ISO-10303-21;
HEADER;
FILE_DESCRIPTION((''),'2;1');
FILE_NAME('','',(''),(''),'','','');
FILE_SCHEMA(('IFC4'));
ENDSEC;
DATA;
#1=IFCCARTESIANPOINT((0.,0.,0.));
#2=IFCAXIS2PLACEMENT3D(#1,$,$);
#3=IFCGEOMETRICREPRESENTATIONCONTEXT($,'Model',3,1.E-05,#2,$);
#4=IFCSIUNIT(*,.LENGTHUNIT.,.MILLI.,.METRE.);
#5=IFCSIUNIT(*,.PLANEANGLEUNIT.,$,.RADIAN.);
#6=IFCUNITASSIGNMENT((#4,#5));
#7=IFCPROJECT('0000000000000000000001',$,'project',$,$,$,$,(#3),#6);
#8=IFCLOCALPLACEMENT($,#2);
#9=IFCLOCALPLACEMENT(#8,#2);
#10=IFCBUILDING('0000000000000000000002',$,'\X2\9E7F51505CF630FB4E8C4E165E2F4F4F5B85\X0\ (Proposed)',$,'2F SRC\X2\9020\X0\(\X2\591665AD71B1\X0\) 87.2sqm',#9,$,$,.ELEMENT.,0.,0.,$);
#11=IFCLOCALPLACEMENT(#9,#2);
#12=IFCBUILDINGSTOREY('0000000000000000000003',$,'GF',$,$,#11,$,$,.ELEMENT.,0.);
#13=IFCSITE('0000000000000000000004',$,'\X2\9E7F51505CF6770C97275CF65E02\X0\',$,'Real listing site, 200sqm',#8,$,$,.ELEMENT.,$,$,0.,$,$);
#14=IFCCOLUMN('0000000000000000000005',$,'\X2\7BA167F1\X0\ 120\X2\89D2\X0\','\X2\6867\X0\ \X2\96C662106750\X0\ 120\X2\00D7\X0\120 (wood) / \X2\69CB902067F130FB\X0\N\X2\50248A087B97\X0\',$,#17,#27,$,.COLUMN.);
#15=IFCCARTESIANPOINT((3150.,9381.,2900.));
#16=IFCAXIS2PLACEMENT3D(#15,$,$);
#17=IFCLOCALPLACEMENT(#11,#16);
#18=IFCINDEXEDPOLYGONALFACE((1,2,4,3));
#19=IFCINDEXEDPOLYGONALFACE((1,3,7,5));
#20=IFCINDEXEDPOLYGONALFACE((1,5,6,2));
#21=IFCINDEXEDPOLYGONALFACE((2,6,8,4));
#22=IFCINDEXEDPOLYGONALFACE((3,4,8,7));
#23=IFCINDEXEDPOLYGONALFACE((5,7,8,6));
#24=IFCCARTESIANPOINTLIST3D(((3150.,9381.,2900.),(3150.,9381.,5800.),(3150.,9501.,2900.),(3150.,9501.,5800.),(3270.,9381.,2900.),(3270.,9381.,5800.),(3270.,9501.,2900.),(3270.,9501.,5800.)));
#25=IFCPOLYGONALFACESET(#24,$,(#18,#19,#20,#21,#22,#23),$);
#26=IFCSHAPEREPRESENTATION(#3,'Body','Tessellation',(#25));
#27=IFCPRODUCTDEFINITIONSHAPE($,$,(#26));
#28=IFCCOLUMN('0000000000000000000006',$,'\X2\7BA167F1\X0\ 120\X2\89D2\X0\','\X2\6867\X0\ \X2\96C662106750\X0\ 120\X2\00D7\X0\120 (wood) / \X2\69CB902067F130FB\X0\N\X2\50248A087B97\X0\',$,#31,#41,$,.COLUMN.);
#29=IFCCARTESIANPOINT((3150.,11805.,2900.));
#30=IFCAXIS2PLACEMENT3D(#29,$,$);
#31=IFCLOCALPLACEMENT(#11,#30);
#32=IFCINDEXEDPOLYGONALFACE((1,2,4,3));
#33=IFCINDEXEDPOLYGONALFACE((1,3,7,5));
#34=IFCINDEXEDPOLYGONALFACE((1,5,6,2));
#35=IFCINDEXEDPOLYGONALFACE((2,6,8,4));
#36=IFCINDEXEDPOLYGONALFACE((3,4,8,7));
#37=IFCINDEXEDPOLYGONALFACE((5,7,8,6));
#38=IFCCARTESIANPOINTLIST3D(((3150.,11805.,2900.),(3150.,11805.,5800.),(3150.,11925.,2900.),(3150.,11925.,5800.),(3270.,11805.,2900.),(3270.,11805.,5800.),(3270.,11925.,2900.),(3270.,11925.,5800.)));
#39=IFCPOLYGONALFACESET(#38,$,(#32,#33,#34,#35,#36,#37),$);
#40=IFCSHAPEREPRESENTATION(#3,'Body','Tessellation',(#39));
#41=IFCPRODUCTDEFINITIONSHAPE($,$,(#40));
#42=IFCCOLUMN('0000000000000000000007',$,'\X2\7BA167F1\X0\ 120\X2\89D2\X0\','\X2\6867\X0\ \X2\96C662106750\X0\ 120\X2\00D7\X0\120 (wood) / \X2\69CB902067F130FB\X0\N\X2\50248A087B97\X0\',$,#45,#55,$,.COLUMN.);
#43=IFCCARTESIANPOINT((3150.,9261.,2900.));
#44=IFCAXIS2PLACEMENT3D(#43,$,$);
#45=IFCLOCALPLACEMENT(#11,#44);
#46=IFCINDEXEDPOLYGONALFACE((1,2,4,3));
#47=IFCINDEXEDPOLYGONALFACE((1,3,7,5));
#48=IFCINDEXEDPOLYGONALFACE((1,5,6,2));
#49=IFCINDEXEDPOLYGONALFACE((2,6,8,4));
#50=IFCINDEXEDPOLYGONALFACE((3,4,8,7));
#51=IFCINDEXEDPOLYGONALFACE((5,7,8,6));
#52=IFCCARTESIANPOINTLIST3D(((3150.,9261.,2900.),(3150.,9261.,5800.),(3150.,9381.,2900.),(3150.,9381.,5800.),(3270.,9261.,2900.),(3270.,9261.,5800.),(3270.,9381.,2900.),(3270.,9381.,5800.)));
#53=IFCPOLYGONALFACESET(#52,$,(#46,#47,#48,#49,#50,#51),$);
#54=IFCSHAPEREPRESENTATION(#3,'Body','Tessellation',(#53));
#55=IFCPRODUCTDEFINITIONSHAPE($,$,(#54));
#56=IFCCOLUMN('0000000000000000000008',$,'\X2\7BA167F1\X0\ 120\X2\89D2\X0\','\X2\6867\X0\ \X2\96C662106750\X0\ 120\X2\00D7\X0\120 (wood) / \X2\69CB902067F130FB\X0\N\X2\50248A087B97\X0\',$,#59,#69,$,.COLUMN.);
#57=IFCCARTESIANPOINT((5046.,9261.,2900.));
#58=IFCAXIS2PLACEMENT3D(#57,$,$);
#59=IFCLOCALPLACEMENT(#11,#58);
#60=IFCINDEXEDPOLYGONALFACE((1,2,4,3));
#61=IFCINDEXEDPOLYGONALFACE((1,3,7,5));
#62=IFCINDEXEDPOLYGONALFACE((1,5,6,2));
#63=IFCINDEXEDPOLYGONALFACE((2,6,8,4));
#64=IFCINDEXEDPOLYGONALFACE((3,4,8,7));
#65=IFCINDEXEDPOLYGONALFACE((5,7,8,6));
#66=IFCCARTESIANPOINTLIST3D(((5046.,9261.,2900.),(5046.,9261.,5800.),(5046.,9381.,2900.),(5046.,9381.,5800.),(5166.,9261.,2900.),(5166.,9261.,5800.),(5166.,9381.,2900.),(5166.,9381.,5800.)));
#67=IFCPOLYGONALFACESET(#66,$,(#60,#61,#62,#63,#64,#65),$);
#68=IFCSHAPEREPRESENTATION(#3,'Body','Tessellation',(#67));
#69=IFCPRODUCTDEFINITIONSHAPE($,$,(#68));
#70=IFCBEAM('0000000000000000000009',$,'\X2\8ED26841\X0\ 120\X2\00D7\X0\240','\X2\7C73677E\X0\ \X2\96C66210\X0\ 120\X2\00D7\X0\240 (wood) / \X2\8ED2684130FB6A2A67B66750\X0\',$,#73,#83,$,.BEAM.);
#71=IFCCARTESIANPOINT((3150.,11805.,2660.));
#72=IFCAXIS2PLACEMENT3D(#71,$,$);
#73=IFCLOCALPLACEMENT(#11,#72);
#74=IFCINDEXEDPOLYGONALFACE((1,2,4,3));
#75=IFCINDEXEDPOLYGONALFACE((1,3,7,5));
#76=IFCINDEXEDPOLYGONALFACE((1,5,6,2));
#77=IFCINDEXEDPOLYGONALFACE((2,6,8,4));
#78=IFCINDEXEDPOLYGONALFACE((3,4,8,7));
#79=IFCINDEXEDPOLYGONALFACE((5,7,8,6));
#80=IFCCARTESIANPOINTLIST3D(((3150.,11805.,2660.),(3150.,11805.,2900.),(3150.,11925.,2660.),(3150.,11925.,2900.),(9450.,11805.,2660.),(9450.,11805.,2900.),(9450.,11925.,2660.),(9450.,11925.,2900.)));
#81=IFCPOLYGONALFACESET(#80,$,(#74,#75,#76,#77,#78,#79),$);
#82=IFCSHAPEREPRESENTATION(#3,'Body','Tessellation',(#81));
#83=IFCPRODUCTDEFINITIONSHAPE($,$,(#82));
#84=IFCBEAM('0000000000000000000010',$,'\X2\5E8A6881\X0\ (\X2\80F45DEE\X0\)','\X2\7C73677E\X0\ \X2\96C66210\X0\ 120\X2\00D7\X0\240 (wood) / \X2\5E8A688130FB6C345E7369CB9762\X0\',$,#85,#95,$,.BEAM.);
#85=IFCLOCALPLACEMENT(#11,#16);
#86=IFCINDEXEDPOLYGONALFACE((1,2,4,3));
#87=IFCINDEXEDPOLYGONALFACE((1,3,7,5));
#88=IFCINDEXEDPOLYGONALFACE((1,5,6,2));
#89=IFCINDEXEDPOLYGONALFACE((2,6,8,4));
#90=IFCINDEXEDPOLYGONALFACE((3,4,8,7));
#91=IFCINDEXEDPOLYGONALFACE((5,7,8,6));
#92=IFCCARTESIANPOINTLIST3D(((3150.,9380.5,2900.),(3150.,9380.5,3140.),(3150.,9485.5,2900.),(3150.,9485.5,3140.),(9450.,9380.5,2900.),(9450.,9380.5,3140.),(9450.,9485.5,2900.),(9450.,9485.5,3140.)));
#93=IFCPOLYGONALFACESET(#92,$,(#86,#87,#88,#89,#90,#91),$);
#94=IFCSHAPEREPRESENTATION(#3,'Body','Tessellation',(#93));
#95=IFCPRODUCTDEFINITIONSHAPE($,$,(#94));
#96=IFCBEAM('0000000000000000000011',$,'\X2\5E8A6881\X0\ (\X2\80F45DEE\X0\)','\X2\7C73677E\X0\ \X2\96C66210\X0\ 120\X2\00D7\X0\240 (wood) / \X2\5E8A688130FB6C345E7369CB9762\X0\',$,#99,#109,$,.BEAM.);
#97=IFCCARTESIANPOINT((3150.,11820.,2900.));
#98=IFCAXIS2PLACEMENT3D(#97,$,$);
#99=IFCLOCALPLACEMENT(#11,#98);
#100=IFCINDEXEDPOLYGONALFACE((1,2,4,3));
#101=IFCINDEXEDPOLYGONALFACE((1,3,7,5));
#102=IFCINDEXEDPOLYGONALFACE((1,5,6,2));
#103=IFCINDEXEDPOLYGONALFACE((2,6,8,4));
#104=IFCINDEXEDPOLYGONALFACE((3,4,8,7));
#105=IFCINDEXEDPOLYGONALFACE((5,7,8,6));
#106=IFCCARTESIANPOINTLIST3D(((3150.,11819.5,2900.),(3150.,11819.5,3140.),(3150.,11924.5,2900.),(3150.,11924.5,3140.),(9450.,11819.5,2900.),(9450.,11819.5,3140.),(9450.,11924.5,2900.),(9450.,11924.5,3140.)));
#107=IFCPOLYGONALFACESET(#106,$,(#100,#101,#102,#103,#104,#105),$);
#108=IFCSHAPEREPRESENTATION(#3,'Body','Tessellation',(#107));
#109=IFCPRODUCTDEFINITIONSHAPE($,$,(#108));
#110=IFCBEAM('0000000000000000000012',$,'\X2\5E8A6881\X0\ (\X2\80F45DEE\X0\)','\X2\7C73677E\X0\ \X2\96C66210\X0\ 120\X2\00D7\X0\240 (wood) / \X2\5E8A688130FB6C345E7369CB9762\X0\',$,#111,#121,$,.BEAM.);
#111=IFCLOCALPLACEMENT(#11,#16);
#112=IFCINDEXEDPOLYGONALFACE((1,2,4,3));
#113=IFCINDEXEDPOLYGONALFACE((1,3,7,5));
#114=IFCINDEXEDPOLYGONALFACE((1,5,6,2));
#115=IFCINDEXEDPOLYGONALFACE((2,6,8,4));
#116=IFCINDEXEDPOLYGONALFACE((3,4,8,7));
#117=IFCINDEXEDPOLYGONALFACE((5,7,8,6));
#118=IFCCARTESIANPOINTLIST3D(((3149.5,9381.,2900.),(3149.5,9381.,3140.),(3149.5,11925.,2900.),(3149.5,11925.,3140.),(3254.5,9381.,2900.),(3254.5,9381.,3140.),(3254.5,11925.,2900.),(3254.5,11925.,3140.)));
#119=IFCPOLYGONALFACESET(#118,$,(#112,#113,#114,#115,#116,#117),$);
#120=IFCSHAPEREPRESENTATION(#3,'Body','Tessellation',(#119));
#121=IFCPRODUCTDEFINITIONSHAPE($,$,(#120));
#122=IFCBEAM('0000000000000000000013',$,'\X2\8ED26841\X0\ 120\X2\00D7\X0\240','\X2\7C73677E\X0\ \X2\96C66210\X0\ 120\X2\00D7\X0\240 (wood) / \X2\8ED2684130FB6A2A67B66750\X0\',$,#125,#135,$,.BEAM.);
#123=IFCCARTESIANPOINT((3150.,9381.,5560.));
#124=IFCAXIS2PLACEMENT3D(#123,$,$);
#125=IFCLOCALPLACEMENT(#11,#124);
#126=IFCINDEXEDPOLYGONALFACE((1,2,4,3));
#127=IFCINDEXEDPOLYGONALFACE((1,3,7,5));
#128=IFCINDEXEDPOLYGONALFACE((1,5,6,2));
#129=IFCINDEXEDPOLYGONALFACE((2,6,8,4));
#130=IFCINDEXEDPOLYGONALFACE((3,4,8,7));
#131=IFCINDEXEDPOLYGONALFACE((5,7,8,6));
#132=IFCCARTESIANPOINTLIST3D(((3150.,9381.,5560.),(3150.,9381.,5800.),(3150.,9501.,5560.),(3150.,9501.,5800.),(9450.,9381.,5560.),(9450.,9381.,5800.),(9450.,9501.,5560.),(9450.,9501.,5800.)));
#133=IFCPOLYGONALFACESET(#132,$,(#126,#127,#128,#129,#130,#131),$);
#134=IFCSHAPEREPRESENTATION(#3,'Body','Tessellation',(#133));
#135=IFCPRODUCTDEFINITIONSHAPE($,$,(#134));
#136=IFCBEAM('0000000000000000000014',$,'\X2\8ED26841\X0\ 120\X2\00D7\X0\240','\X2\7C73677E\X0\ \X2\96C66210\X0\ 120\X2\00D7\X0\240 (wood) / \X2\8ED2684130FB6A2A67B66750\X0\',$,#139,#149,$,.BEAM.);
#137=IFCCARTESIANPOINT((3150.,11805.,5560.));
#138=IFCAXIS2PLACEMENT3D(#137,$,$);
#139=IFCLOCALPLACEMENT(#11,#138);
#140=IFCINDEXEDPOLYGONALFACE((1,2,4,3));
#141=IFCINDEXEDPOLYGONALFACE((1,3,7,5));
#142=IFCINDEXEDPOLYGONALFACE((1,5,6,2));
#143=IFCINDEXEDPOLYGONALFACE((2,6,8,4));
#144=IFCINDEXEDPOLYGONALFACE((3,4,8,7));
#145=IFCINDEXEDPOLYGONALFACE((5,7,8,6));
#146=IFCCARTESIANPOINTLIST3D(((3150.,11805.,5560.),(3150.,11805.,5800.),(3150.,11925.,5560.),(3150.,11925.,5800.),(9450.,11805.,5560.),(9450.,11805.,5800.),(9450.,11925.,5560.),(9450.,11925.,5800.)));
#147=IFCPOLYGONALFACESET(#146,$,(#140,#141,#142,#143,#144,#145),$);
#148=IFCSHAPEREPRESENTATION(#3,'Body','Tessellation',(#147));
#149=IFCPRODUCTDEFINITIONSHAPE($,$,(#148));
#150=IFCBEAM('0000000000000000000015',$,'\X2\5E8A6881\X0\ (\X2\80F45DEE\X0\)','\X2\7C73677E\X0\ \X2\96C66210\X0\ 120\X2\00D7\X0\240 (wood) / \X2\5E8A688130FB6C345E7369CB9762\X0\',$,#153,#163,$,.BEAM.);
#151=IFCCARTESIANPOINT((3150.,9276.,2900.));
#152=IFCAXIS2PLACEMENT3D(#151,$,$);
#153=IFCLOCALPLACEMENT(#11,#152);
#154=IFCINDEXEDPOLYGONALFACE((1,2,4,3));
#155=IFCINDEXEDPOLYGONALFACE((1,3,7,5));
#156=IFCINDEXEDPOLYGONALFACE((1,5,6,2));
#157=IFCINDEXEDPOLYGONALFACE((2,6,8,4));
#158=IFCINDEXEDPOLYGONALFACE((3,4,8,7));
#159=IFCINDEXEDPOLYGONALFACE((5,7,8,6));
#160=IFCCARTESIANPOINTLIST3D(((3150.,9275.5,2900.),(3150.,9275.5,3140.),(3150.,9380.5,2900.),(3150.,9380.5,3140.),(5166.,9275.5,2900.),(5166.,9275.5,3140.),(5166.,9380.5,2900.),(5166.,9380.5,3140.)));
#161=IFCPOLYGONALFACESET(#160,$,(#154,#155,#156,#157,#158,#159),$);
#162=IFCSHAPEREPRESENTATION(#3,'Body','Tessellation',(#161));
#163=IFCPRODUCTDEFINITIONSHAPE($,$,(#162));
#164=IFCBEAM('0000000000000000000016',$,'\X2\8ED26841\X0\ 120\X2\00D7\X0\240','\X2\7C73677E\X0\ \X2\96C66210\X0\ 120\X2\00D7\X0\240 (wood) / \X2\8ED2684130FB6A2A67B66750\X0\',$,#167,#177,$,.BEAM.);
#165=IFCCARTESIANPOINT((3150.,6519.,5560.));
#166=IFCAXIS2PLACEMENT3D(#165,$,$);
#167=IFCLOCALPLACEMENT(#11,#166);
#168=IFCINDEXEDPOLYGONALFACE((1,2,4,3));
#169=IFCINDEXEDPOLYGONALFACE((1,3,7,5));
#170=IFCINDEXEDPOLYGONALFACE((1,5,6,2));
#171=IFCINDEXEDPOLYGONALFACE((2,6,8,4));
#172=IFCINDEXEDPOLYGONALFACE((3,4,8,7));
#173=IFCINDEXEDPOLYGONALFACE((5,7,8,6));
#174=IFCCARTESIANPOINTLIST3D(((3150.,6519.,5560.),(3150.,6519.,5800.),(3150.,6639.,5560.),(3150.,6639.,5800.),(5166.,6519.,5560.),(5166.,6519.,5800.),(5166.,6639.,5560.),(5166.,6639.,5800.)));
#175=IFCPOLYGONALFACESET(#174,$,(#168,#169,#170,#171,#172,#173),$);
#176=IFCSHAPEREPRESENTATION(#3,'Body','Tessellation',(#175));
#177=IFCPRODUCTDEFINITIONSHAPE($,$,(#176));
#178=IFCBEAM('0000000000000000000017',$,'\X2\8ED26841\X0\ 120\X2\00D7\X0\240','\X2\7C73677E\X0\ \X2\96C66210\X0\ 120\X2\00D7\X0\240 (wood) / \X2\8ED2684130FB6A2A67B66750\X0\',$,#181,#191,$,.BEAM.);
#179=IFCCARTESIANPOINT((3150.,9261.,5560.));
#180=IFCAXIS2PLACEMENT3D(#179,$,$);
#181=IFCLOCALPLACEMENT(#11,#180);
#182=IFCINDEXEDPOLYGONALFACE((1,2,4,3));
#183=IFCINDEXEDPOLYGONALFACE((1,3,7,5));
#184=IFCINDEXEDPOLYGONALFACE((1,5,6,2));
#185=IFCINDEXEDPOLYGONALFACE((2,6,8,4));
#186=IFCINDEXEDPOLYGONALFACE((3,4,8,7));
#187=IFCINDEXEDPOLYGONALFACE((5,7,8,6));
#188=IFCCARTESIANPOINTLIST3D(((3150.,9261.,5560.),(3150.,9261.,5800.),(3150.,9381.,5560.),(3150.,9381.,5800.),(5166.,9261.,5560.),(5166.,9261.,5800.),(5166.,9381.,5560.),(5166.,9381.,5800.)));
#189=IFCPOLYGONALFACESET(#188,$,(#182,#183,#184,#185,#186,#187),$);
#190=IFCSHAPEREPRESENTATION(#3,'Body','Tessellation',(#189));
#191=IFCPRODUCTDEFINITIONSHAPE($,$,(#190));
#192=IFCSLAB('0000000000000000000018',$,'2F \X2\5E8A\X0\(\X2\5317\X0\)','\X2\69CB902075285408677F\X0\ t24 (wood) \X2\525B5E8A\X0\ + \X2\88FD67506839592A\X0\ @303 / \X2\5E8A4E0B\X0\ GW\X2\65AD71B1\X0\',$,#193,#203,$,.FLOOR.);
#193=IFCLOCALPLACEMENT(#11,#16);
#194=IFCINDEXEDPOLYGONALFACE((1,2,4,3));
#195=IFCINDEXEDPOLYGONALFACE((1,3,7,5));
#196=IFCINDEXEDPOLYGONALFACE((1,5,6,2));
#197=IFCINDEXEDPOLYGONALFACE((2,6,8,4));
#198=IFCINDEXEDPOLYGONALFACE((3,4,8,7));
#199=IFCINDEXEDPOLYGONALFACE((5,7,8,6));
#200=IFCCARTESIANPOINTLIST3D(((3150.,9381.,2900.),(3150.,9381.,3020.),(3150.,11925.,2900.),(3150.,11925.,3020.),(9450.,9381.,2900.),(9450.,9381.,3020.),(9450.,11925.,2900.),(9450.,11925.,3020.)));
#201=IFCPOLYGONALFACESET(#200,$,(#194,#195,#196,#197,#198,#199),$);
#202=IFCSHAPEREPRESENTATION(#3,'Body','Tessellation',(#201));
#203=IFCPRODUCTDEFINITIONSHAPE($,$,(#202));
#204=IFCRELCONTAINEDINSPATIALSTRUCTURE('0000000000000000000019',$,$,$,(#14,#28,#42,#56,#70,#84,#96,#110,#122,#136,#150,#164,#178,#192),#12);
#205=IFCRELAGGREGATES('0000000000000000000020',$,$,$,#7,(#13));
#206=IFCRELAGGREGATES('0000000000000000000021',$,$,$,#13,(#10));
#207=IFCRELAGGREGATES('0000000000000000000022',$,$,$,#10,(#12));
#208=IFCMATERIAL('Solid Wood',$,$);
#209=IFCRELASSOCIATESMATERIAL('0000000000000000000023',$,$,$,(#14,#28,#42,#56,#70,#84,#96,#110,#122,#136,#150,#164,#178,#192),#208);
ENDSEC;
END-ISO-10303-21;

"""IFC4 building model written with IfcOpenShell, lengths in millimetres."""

from ifc_helpers import new_model, si_unit, frame, frame_2d, origin, place, context, project, spatial, rectangle, extrude, material, element, save


model = new_model("IFC4")

# Units and contexts
model_context = context("Model", 3, precision=1e-05, world=origin())
ifc_project = project(units=[si_unit("LENGTHUNIT", "METRE", prefix="MILLI"), si_unit("PLANEANGLEUNIT", "RADIAN")], contexts=[model_context])

# Site, building, storey
site_placement = place(None, origin())
site = spatial("IfcSite", under=ifc_project, at=site_placement, Name="鹿児島県霧島市", ObjectType="Real listing site, 200sqm", CompositionType="ELEMENT", RefElevation=0.0)
building_placement = place(site_placement, origin())
building = spatial("IfcBuilding", under=site, at=building_placement, Name="鹿児島・二世帯住宅 (Proposed)", ObjectType="2F SRC造(外断熱) 87.2sqm", CompositionType="ELEMENT", ElevationOfRefHeight=0.0, ElevationOfTerrain=0.0)
storey_placement = place(building_placement, origin())
storey = spatial("IfcBuildingStorey", under=building, at=storey_placement, Name="GF", CompositionType="ELEMENT", Elevation=0.0)

# Columns
ifc_material_1 = material(Name="Solid Wood")
column_1_placement = place(storey_placement, frame((3150.0, 9381.0, 2900.0)))
element("IfcColumn", 1, at=column_1_placement, inside=storey, material=ifc_material_1, Name="管柱 120角", Description="桧 集成材 120×120 (wood) / 構造柱・N値計算", PredefinedType="COLUMN", context=model_context, shape_type="SweptSolid", body=[
    extrude(rectangle(XDim=120.0, YDim=120.0, at=frame_2d((60.0, 60.0))), frame((3150.0, 9381.0, 2900.0)), (0.0, 0.0, 1.0), 2900.0),
])
column_2_placement = place(storey_placement, frame((3150.0, 11805.0, 2900.0)))
element("IfcColumn", 2, at=column_2_placement, inside=storey, material=ifc_material_1, Name="管柱 120角", Description="桧 集成材 120×120 (wood) / 構造柱・N値計算", PredefinedType="COLUMN", context=model_context, shape_type="SweptSolid", body=[
    extrude(rectangle(XDim=120.0, YDim=120.0, at=frame_2d((60.0, 60.0))), frame((3150.0, 11805.0, 2900.0)), (0.0, 0.0, 1.0), 2900.0),
])
column_3_placement = place(storey_placement, frame((3150.0, 9261.0, 2900.0)))
element("IfcColumn", 3, at=column_3_placement, inside=storey, material=ifc_material_1, Name="管柱 120角", Description="桧 集成材 120×120 (wood) / 構造柱・N値計算", PredefinedType="COLUMN", context=model_context, shape_type="SweptSolid", body=[
    extrude(rectangle(XDim=120.0, YDim=120.0, at=frame_2d((60.0, 60.0))), frame((3150.0, 9261.0, 2900.0)), (0.0, 0.0, 1.0), 2900.0),
])
column_4_placement = place(storey_placement, frame((5046.0, 9261.0, 2900.0)))
element("IfcColumn", 4, at=column_4_placement, inside=storey, material=ifc_material_1, Name="管柱 120角", Description="桧 集成材 120×120 (wood) / 構造柱・N値計算", PredefinedType="COLUMN", context=model_context, shape_type="SweptSolid", body=[
    extrude(rectangle(XDim=120.0, YDim=120.0, at=frame_2d((60.0, 60.0))), frame((5046.0, 9261.0, 2900.0)), (0.0, 0.0, 1.0), 2900.0),
])

# Beams
beam_1_placement = place(storey_placement, frame((3150.0, 11805.0, 2660.0)))
element("IfcBeam", 5, at=beam_1_placement, inside=storey, material=ifc_material_1, Name="軒桁 120×240", Description="米松 集成 120×240 (wood) / 軒桁・横架材", PredefinedType="BEAM", context=model_context, shape_type="SweptSolid", body=[
    extrude(rectangle(XDim=6300.0, YDim=120.0, at=frame_2d((3150.0, 60.0))), frame((3150.0, 11805.0, 2660.0)), (0.0, 0.0, 1.0), 240.0),
])
beam_2_placement = place(storey_placement, frame((3150.0, 9381.0, 2900.0)))
element("IfcBeam", 6, at=beam_2_placement, inside=storey, material=ifc_material_1, Name="床梁 (胴差)", Description="米松 集成 120×240 (wood) / 床梁・水平構面", PredefinedType="BEAM", context=model_context, shape_type="SweptSolid", body=[
    extrude(rectangle(XDim=6300.0, YDim=105.0, at=frame_2d((3150.0, 52.0))), frame((3150.0, 9381.0, 2900.0)), (0.0, 0.0, 1.0), 240.0),
])
beam_3_placement = place(storey_placement, frame((3150.0, 11820.0, 2900.0)))
element("IfcBeam", 7, at=beam_3_placement, inside=storey, material=ifc_material_1, Name="床梁 (胴差)", Description="米松 集成 120×240 (wood) / 床梁・水平構面", PredefinedType="BEAM", context=model_context, shape_type="SweptSolid", body=[
    extrude(rectangle(XDim=6300.0, YDim=105.0, at=frame_2d((3150.0, 52.0))), frame((3150.0, 11820.0, 2900.0)), (0.0, 0.0, 1.0), 240.0),
])
beam_4_placement = place(storey_placement, frame((3150.0, 9381.0, 2900.0)))
element("IfcBeam", 8, at=beam_4_placement, inside=storey, material=ifc_material_1, Name="床梁 (胴差)", Description="米松 集成 120×240 (wood) / 床梁・水平構面", PredefinedType="BEAM", context=model_context, shape_type="SweptSolid", body=[
    extrude(rectangle(XDim=105.0, YDim=2544.0, at=frame_2d((52.0, 1272.0))), frame((3150.0, 9381.0, 2900.0)), (0.0, 0.0, 1.0), 240.0),
])
beam_5_placement = place(storey_placement, frame((3150.0, 9381.0, 5560.0)))
element("IfcBeam", 9, at=beam_5_placement, inside=storey, material=ifc_material_1, Name="軒桁 120×240", Description="米松 集成 120×240 (wood) / 軒桁・横架材", PredefinedType="BEAM", context=model_context, shape_type="SweptSolid", body=[
    extrude(rectangle(XDim=6300.0, YDim=120.0, at=frame_2d((3150.0, 60.0))), frame((3150.0, 9381.0, 5560.0)), (0.0, 0.0, 1.0), 240.0),
])
beam_6_placement = place(storey_placement, frame((3150.0, 11805.0, 5560.0)))
element("IfcBeam", 10, at=beam_6_placement, inside=storey, material=ifc_material_1, Name="軒桁 120×240", Description="米松 集成 120×240 (wood) / 軒桁・横架材", PredefinedType="BEAM", context=model_context, shape_type="SweptSolid", body=[
    extrude(rectangle(XDim=6300.0, YDim=120.0, at=frame_2d((3150.0, 60.0))), frame((3150.0, 11805.0, 5560.0)), (0.0, 0.0, 1.0), 240.0),
])
beam_7_placement = place(storey_placement, frame((3150.0, 9276.0, 2900.0)))
element("IfcBeam", 11, at=beam_7_placement, inside=storey, material=ifc_material_1, Name="床梁 (胴差)", Description="米松 集成 120×240 (wood) / 床梁・水平構面", PredefinedType="BEAM", context=model_context, shape_type="SweptSolid", body=[
    extrude(rectangle(XDim=2016.0, YDim=105.0, at=frame_2d((1008.0, 52.0))), frame((3150.0, 9276.0, 2900.0)), (0.0, 0.0, 1.0), 240.0),
])
beam_8_placement = place(storey_placement, frame((3150.0, 6519.0, 5560.0)))
element("IfcBeam", 12, at=beam_8_placement, inside=storey, material=ifc_material_1, Name="軒桁 120×240", Description="米松 集成 120×240 (wood) / 軒桁・横架材", PredefinedType="BEAM", context=model_context, shape_type="SweptSolid", body=[
    extrude(rectangle(XDim=2016.0, YDim=120.0, at=frame_2d((1008.0, 60.0))), frame((3150.0, 6519.0, 5560.0)), (0.0, 0.0, 1.0), 240.0),
])
beam_9_placement = place(storey_placement, frame((3150.0, 9261.0, 5560.0)))
element("IfcBeam", 13, at=beam_9_placement, inside=storey, material=ifc_material_1, Name="軒桁 120×240", Description="米松 集成 120×240 (wood) / 軒桁・横架材", PredefinedType="BEAM", context=model_context, shape_type="SweptSolid", body=[
    extrude(rectangle(XDim=2016.0, YDim=120.0, at=frame_2d((1008.0, 60.0))), frame((3150.0, 9261.0, 5560.0)), (0.0, 0.0, 1.0), 240.0),
])

# Slab
slab_placement = place(storey_placement, frame((3150.0, 9381.0, 2900.0)))
element("IfcSlab", 14, at=slab_placement, inside=storey, material=ifc_material_1, Name="2F 床(北)", Description="構造用合板 t24 (wood) 剛床 + 製材根太 @303 / 床下 GW断熱", PredefinedType="FLOOR", context=model_context, shape_type="SweptSolid", body=[
    extrude(rectangle(XDim=6300.0, YDim=2544.0, at=frame_2d((3150.0, 1272.0))), frame((3150.0, 9381.0, 2900.0)), (0.0, 0.0, 1.0), 120.0),
])

save(model, "model.ifc")
